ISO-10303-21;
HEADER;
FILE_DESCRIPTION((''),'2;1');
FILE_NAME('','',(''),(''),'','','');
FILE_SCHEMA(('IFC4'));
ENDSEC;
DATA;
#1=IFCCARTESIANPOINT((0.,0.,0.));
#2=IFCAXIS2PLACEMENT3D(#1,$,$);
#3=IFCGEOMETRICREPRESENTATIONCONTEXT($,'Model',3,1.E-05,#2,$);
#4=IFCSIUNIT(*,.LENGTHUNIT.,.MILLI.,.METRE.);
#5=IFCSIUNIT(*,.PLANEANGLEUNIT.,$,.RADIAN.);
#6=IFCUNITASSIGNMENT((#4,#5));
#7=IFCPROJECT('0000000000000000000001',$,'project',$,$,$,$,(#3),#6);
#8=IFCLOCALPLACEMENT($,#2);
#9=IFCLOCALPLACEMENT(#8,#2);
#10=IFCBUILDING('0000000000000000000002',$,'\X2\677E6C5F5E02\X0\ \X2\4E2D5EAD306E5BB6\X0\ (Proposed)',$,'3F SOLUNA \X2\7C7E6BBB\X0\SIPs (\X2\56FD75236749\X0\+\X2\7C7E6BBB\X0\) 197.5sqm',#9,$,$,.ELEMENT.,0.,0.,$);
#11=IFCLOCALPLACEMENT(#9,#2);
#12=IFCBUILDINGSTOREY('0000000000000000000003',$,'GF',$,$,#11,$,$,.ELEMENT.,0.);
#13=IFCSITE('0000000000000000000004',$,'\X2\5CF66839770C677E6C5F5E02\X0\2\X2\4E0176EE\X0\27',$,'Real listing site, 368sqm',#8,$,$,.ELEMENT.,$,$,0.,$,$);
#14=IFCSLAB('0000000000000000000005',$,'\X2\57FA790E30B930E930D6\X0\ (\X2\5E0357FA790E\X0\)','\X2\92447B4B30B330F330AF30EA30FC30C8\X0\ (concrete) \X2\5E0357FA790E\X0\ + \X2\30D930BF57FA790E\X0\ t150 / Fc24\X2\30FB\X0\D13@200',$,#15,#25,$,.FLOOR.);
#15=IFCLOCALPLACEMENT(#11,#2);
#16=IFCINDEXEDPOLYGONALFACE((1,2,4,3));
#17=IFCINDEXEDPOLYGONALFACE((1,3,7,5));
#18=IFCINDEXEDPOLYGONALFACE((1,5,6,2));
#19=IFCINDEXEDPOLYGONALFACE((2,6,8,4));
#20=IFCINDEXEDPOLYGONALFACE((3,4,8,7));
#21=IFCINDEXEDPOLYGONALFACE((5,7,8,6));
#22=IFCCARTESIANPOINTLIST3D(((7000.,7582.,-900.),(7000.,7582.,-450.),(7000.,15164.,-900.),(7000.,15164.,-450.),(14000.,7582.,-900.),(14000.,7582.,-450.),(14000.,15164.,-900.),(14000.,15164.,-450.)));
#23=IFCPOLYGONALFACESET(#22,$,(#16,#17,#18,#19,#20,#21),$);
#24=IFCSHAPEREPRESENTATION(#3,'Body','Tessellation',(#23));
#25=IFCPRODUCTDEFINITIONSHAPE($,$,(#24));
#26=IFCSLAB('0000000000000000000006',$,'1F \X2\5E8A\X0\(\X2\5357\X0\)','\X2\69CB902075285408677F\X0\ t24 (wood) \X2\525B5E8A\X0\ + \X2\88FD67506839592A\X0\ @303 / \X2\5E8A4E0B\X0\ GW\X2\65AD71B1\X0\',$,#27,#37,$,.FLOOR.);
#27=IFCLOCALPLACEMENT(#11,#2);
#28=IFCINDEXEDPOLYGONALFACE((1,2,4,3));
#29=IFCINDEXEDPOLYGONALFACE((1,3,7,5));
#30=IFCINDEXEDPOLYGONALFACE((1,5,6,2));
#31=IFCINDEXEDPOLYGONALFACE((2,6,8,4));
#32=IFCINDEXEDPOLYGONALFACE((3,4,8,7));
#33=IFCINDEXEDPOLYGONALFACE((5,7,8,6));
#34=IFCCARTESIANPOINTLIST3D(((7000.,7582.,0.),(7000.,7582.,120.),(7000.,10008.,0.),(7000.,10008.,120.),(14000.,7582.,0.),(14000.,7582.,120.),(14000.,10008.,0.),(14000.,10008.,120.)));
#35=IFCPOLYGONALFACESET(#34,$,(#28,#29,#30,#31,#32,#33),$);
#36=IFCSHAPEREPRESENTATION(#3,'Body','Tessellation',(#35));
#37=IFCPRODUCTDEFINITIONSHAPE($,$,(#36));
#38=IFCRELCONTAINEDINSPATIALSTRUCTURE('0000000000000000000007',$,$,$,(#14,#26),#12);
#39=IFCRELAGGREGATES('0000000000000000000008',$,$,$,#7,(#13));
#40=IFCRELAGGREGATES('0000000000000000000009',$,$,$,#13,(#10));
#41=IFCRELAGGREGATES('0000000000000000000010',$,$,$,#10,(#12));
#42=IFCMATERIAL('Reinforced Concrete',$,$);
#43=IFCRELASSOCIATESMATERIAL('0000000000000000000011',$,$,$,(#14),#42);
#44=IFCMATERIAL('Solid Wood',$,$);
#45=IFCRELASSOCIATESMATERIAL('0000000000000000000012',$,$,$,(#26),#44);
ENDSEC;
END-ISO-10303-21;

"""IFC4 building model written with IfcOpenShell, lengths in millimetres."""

from ifc_helpers import new_model, si_unit, frame, frame_2d, origin, place, context, project, spatial, rectangle, extrude, material, element, save


model = new_model("IFC4")

# Units and contexts
model_context = context("Model", 3, precision=1e-05, world=origin())
ifc_project = project(units=[si_unit("LENGTHUNIT", "METRE", prefix="MILLI"), si_unit("PLANEANGLEUNIT", "RADIAN")], contexts=[model_context])

# Site, building, storey
site_placement = place(None, origin())
site = spatial("IfcSite", under=ifc_project, at=site_placement, Name="島根県松江市2丁目27", ObjectType="Real listing site, 368sqm", CompositionType="ELEMENT", RefElevation=0.0)
building_placement = place(site_placement, origin())
building = spatial("IfcBuilding", under=site, at=building_placement, Name="松江市 中庭の家 (Proposed)", ObjectType="3F SOLUNA 籾殻SIPs (国産杉+籾殻) 197.5sqm", CompositionType="ELEMENT", ElevationOfRefHeight=0.0, ElevationOfTerrain=0.0)
storey_placement = place(building_placement, origin())
storey = spatial("IfcBuildingStorey", under=building, at=storey_placement, Name="GF", CompositionType="ELEMENT", Elevation=0.0)

# Slabs
ifc_material_1 = material(Name="Reinforced Concrete")
slab_1_placement = place(storey_placement, frame((3500.0, 3791.0, -450.0)))
element("IfcSlab", 1, at=slab_1_placement, inside=storey, material=ifc_material_1, Name="基礎スラブ (布基礎)", Description="鉄筋コンクリート (concrete) 布基礎 + ベタ基礎 t150 / Fc24・D13@200", PredefinedType="FLOOR", context=model_context, shape_type="SweptSolid", body=[
    extrude(rectangle(XDim=7000.0, YDim=7582.0, at=frame_2d((3500.0, 3791.0))), frame((3500.0, 3791.0, -450.0)), (0.0, 0.0, 1.0), 450.0),
])
ifc_material_2 = material(Name="Solid Wood")
slab_2_placement = place(storey_placement, frame((3500.0, 3791.0, 0.0)))
element("IfcSlab", 2, at=slab_2_placement, inside=storey, material=ifc_material_2, Name="1F 床(南)", Description="構造用合板 t24 (wood) 剛床 + 製材根太 @303 / 床下 GW断熱", PredefinedType="FLOOR", context=model_context, shape_type="SweptSolid", body=[
    extrude(rectangle(XDim=7000.0, YDim=2426.0, at=frame_2d((3500.0, 1213.0))), frame((3500.0, 3791.0, 0.0)), (0.0, 0.0, 1.0), 120.0),
])

save(model, "model.ifc")
